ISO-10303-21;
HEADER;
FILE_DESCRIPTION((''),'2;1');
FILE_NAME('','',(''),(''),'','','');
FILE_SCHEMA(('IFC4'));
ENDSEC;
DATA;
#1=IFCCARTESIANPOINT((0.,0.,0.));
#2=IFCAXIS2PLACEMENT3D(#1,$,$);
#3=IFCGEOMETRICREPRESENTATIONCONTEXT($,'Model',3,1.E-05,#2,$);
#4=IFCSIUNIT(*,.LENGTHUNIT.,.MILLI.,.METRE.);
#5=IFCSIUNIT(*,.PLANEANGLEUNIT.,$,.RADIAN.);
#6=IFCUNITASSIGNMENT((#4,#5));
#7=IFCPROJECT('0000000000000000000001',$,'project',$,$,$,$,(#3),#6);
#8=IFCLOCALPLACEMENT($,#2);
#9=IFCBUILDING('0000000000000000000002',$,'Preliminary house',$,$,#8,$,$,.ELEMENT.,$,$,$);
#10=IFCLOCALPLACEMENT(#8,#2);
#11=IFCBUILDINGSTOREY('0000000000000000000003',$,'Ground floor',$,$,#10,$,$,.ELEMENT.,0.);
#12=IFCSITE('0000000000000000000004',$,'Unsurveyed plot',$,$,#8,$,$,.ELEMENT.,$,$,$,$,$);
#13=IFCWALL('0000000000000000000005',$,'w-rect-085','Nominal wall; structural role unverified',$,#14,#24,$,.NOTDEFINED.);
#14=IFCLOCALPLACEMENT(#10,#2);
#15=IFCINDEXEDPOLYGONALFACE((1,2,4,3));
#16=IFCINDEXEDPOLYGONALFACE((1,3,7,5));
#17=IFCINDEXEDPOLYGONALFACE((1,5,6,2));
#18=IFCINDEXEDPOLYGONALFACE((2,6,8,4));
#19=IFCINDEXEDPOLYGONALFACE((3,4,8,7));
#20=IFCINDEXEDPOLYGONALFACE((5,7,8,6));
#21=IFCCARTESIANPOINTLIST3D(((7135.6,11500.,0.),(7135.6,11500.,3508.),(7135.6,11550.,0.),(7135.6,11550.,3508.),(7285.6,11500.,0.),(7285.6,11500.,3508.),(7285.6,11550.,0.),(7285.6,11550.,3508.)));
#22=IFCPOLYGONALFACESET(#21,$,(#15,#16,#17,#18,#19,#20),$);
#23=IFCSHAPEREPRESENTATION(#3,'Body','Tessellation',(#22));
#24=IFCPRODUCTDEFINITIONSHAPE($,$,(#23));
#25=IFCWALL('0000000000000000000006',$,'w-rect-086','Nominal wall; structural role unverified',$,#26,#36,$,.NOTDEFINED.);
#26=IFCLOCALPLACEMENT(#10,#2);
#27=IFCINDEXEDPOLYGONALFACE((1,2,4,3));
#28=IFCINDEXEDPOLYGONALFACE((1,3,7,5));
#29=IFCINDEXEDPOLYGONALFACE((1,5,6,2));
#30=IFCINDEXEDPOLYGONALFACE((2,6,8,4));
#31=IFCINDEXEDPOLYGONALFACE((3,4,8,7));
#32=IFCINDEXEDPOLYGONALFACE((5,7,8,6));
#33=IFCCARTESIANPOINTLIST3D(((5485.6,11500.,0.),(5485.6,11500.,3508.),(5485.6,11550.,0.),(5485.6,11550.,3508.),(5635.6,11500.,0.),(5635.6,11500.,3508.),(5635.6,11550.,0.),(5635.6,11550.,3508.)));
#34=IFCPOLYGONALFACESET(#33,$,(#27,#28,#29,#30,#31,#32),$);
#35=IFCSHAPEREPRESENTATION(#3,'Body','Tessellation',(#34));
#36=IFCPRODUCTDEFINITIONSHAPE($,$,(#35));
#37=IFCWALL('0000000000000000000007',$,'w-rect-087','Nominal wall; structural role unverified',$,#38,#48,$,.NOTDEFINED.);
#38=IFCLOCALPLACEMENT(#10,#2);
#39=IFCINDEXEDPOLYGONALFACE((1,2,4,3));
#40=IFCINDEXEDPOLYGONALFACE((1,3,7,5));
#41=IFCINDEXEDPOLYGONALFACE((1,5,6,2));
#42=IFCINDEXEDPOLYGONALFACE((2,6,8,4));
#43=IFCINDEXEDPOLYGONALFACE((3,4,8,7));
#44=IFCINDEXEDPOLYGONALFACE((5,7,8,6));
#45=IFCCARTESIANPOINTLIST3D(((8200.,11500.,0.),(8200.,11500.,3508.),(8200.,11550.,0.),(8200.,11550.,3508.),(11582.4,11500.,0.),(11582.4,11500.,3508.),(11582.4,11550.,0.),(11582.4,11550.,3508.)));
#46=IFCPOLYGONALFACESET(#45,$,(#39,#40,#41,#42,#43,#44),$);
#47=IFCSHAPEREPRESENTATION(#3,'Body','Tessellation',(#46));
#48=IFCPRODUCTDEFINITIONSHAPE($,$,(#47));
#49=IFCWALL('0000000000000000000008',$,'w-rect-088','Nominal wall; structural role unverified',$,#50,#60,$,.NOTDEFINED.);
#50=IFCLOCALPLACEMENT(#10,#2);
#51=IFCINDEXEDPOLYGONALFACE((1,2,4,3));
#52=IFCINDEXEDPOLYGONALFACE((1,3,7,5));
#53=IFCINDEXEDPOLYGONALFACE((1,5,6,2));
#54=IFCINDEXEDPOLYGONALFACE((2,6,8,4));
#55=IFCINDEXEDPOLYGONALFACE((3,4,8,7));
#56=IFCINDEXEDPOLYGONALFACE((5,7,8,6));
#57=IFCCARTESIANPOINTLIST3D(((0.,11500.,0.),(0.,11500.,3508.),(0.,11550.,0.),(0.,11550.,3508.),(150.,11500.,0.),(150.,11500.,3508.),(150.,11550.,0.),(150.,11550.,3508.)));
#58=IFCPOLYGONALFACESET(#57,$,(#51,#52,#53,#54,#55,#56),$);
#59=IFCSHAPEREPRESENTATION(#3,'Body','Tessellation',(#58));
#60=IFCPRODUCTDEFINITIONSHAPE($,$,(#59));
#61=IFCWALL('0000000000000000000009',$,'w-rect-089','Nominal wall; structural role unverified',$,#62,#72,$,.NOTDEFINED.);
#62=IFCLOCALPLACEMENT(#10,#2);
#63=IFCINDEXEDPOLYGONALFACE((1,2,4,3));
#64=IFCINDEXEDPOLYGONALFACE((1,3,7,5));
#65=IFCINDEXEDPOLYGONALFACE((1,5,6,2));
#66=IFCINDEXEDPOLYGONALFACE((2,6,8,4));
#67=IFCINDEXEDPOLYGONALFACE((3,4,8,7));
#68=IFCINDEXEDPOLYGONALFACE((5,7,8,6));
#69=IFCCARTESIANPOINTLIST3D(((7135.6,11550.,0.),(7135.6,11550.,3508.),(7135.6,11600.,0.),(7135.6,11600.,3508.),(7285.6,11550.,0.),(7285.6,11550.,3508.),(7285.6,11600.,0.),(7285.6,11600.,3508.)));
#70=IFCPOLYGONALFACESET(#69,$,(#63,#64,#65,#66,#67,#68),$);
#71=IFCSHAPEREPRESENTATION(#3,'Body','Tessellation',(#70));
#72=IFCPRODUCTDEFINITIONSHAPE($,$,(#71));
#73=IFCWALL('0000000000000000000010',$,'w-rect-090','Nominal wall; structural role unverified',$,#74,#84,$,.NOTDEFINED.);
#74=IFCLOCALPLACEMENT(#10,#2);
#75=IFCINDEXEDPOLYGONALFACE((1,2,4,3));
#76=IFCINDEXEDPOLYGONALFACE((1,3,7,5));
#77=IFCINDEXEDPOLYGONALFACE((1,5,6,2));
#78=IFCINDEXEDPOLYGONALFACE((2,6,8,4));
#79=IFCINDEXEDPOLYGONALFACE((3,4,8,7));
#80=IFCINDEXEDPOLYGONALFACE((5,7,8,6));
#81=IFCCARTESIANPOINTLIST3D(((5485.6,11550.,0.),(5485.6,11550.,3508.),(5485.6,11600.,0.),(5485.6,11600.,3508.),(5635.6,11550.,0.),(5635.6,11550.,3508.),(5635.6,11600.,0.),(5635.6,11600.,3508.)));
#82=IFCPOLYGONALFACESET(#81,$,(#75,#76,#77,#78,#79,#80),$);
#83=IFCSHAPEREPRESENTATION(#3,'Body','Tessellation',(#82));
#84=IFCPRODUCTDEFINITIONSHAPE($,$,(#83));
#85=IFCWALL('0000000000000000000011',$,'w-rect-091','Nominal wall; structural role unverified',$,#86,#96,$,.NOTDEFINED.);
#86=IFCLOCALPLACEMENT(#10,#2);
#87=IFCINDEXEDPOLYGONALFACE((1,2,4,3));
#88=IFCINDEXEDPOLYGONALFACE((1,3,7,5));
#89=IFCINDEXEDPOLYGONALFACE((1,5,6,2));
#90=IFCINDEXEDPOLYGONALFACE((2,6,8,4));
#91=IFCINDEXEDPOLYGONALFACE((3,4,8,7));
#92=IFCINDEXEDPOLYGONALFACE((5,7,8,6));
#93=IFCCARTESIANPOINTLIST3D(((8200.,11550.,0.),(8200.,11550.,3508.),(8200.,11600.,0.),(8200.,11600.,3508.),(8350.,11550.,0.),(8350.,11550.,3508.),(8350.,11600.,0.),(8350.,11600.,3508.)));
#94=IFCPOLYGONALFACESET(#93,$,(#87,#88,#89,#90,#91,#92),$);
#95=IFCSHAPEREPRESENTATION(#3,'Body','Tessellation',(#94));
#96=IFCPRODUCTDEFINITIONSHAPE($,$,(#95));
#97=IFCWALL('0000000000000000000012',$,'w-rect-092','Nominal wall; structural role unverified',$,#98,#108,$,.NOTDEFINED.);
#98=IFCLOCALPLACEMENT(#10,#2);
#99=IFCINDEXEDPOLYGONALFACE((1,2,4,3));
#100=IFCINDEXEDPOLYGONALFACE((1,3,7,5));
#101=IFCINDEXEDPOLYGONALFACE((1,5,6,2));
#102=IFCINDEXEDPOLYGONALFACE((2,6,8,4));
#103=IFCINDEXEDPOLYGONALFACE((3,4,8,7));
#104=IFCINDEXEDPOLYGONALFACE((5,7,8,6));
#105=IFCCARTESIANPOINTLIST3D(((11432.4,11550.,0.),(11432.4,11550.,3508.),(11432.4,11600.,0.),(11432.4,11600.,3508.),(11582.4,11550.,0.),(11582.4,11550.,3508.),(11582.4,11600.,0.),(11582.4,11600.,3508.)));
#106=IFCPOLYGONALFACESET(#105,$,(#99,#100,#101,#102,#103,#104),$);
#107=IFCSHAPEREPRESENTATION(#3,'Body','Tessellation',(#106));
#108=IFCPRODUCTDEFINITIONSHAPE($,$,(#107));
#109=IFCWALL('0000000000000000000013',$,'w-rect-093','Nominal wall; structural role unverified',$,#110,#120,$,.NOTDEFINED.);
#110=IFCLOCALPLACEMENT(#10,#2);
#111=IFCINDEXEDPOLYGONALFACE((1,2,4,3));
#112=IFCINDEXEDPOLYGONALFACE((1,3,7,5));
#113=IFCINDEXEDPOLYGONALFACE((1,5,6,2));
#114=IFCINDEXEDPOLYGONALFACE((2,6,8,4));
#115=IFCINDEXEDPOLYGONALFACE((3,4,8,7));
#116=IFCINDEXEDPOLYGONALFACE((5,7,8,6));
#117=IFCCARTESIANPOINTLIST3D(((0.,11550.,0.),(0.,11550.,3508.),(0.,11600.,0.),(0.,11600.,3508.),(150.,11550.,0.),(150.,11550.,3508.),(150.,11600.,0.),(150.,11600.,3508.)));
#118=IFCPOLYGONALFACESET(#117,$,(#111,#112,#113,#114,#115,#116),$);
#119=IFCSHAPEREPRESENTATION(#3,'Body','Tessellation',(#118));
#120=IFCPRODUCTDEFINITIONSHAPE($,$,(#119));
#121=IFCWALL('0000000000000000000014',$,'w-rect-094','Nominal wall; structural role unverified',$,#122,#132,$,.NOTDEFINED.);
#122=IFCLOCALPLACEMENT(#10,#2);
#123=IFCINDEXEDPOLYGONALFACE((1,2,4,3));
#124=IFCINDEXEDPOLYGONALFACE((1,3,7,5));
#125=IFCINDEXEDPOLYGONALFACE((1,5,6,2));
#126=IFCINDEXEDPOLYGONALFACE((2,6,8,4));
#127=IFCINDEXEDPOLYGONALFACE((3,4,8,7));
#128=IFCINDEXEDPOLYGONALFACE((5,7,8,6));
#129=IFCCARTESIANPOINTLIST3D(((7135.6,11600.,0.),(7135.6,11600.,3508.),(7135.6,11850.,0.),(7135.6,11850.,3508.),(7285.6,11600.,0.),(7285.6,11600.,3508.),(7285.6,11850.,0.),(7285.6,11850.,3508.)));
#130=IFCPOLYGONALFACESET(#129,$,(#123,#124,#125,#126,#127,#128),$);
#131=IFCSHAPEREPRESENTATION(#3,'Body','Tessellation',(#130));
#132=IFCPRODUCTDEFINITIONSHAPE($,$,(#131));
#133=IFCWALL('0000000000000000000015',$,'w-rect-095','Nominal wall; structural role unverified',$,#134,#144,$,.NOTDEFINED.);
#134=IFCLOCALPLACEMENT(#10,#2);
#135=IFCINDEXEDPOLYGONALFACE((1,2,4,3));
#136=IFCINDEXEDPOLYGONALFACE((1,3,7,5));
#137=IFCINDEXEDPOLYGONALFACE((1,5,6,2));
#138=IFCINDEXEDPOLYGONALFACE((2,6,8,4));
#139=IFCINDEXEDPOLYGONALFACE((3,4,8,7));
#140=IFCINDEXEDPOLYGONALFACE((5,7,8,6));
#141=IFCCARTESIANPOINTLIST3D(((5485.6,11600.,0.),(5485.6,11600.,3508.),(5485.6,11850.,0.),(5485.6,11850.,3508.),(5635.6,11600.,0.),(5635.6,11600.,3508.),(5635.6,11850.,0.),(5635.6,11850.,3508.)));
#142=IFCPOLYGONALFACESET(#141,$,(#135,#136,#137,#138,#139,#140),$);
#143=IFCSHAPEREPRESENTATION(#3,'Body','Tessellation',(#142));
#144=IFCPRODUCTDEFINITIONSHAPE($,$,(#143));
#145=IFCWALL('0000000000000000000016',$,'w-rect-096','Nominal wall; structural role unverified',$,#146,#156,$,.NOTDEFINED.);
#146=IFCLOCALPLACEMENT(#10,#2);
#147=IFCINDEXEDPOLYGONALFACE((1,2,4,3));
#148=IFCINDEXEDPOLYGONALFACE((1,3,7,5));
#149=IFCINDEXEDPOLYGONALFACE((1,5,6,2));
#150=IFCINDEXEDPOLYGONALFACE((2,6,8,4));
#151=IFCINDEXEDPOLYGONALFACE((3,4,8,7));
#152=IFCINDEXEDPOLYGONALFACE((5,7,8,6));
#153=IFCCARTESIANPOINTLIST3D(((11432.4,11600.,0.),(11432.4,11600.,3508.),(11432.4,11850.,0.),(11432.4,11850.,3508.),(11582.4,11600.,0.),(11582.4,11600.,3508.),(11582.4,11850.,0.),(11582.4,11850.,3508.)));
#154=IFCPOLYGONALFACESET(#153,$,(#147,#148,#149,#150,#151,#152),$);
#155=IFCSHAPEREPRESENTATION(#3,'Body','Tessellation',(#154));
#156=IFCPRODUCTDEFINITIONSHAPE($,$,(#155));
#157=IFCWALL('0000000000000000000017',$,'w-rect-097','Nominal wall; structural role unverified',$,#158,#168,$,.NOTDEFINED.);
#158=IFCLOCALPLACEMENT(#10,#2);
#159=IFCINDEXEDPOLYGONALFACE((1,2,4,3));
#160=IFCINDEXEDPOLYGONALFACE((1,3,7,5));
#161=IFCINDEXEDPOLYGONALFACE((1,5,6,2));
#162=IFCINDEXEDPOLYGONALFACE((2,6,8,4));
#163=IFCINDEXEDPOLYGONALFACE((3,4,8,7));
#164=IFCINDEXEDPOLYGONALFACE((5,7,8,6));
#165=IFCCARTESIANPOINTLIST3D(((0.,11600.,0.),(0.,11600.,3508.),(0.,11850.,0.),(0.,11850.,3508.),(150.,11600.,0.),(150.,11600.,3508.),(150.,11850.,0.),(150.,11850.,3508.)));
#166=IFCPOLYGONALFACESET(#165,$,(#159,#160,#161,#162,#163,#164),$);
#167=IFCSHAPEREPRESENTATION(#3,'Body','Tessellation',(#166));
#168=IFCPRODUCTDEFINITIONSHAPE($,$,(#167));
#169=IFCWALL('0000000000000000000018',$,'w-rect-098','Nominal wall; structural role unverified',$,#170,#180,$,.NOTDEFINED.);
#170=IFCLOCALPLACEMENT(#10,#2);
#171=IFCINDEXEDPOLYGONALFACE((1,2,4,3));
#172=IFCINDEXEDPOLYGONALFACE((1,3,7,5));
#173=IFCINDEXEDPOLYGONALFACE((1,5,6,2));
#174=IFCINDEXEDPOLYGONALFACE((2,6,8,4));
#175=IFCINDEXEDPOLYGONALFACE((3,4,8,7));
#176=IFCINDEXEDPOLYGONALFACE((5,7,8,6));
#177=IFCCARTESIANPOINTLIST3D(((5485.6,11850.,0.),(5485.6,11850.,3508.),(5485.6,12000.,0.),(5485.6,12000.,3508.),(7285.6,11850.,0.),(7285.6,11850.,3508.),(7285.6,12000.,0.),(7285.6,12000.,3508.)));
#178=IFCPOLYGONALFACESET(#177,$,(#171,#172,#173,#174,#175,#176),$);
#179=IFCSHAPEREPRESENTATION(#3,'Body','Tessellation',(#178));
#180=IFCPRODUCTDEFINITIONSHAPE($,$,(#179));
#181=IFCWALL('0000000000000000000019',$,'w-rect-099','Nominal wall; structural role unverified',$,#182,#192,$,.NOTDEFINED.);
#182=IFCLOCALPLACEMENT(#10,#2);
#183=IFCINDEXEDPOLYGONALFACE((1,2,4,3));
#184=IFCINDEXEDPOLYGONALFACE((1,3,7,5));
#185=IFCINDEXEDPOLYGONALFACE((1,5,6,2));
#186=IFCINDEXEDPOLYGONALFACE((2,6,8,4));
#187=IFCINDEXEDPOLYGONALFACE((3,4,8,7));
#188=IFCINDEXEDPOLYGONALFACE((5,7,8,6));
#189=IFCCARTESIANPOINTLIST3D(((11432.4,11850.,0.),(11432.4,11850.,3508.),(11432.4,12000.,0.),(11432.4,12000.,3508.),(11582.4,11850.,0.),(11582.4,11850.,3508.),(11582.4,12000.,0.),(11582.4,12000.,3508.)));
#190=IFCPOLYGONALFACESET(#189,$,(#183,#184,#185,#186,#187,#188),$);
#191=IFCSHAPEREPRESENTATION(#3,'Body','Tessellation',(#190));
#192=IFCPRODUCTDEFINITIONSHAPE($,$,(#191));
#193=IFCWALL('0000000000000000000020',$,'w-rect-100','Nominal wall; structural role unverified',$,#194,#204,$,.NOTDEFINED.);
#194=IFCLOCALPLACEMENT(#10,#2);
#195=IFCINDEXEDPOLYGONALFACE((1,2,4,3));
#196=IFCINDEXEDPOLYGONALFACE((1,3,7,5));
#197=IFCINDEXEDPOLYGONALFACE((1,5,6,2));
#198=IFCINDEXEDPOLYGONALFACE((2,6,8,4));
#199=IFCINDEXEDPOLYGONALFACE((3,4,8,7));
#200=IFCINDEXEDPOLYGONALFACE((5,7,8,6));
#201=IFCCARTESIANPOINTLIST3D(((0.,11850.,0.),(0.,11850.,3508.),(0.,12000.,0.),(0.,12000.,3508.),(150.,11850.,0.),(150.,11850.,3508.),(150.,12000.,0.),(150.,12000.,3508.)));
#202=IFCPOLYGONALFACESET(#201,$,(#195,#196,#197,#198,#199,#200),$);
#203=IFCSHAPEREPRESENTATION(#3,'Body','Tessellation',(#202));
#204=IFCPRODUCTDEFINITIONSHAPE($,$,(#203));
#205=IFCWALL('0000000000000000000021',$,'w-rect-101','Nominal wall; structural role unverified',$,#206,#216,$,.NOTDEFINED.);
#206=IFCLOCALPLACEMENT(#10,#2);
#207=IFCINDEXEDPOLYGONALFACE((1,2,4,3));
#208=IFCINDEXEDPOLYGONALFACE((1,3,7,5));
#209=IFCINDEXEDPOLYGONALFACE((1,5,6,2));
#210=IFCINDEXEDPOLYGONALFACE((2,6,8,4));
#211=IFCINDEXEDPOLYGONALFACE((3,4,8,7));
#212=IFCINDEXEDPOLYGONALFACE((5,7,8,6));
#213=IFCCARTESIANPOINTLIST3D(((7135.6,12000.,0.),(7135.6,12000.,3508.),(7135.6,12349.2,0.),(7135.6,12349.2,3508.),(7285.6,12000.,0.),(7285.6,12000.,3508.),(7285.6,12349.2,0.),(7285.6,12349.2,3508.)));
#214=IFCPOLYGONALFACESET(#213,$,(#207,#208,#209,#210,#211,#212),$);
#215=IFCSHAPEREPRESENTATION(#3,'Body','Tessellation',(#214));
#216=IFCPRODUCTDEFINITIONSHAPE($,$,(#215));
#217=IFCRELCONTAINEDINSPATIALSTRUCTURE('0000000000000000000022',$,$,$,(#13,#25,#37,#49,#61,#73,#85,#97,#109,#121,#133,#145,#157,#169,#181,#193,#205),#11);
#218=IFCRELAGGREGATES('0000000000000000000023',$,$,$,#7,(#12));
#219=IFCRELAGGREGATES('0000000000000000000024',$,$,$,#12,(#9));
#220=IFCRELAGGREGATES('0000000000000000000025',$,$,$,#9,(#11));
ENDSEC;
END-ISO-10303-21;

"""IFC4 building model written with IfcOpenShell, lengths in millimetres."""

from ifc_helpers import new_model, si_unit, origin, place, context, project, spatial, polyline, outline, extrude, element, save


model = new_model("IFC4")

# Units and contexts
model_context = context("Model", 3, precision=1e-05, world=origin())
ifc_project = project(units=[si_unit("LENGTHUNIT", "METRE", prefix="MILLI"), si_unit("PLANEANGLEUNIT", "RADIAN")], contexts=[model_context])

# Site, building, storey
placement_1 = place(None, origin())
site = spatial("IfcSite", under=ifc_project, at=placement_1, Name="Unsurveyed plot", CompositionType="ELEMENT")
building = spatial("IfcBuilding", under=site, at=placement_1, Name="Preliminary house", CompositionType="ELEMENT")
placement_2 = place(placement_1, origin())
storey = spatial("IfcBuildingStorey", under=building, at=placement_2, Name="Ground floor", CompositionType="ELEMENT", Elevation=0.0)

# Walls
element("IfcWall", 1, at=placement_2, inside=storey, Name="w-rect-085", Description="Nominal wall; structural role unverified", PredefinedType="NOTDEFINED", context=model_context, shape_type="SweptSolid", body=[
    extrude(outline(polyline([(7135.6, 11500.0), (7285.6, 11500.0), (7285.6, 11550.0), (7135.6, 11550.0), (7135.6, 11500.0)])), origin(), (0.0, 0.0, 1.0), 3508.0),
])
element("IfcWall", 2, at=placement_2, inside=storey, Name="w-rect-086", Description="Nominal wall; structural role unverified", PredefinedType="NOTDEFINED", context=model_context, shape_type="SweptSolid", body=[
    extrude(outline(polyline([(5485.6, 11500.0), (5635.6, 11500.0), (5635.6, 11550.0), (5485.6, 11550.0), (5485.6, 11500.0)])), origin(), (0.0, 0.0, 1.0), 3508.0),
])
element("IfcWall", 3, at=placement_2, inside=storey, Name="w-rect-087", Description="Nominal wall; structural role unverified", PredefinedType="NOTDEFINED", context=model_context, shape_type="SweptSolid", body=[
    extrude(outline(polyline([(8200.0, 11500.0), (11582.4, 11500.0), (11582.4, 11550.0), (8200.0, 11550.0), (8200.0, 11500.0)])), origin(), (0.0, 0.0, 1.0), 3508.0),
])
element("IfcWall", 4, at=placement_2, inside=storey, Name="w-rect-088", Description="Nominal wall; structural role unverified", PredefinedType="NOTDEFINED", context=model_context, shape_type="SweptSolid", body=[
    extrude(outline(polyline([(0.0, 11500.0), (150.0, 11500.0), (150.0, 11550.0), (0.0, 11550.0), (0.0, 11500.0)])), origin(), (0.0, 0.0, 1.0), 3508.0),
])
element("IfcWall", 5, at=placement_2, inside=storey, Name="w-rect-089", Description="Nominal wall; structural role unverified", PredefinedType="NOTDEFINED", context=model_context, shape_type="SweptSolid", body=[
    extrude(outline(polyline([(7135.6, 11550.0), (7285.6, 11550.0), (7285.6, 11600.0), (7135.6, 11600.0), (7135.6, 11550.0)])), origin(), (0.0, 0.0, 1.0), 3508.0),
])
element("IfcWall", 6, at=placement_2, inside=storey, Name="w-rect-090", Description="Nominal wall; structural role unverified", PredefinedType="NOTDEFINED", context=model_context, shape_type="SweptSolid", body=[
    extrude(outline(polyline([(5485.6, 11550.0), (5635.6, 11550.0), (5635.6, 11600.0), (5485.6, 11600.0), (5485.6, 11550.0)])), origin(), (0.0, 0.0, 1.0), 3508.0),
])
element("IfcWall", 7, at=placement_2, inside=storey, Name="w-rect-091", Description="Nominal wall; structural role unverified", PredefinedType="NOTDEFINED", context=model_context, shape_type="SweptSolid", body=[
    extrude(outline(polyline([(8200.0, 11550.0), (8350.0, 11550.0), (8350.0, 11600.0), (8200.0, 11600.0), (8200.0, 11550.0)])), origin(), (0.0, 0.0, 1.0), 3508.0),
])
element("IfcWall", 8, at=placement_2, inside=storey, Name="w-rect-092", Description="Nominal wall; structural role unverified", PredefinedType="NOTDEFINED", context=model_context, shape_type="SweptSolid", body=[
    extrude(outline(polyline([(11432.4, 11550.0), (11582.4, 11550.0), (11582.4, 11600.0), (11432.4, 11600.0), (11432.4, 11550.0)])), origin(), (0.0, 0.0, 1.0), 3508.0),
])
element("IfcWall", 9, at=placement_2, inside=storey, Name="w-rect-093", Description="Nominal wall; structural role unverified", PredefinedType="NOTDEFINED", context=model_context, shape_type="SweptSolid", body=[
    extrude(outline(polyline([(0.0, 11550.0), (150.0, 11550.0), (150.0, 11600.0), (0.0, 11600.0), (0.0, 11550.0)])), origin(), (0.0, 0.0, 1.0), 3508.0),
])
element("IfcWall", 10, at=placement_2, inside=storey, Name="w-rect-094", Description="Nominal wall; structural role unverified", PredefinedType="NOTDEFINED", context=model_context, shape_type="SweptSolid", body=[
    extrude(outline(polyline([(7135.6, 11600.0), (7285.6, 11600.0), (7285.6, 11850.0), (7135.6, 11850.0), (7135.6, 11600.0)])), origin(), (0.0, 0.0, 1.0), 3508.0),
])
element("IfcWall", 11, at=placement_2, inside=storey, Name="w-rect-095", Description="Nominal wall; structural role unverified", PredefinedType="NOTDEFINED", context=model_context, shape_type="SweptSolid", body=[
    extrude(outline(polyline([(5485.6, 11600.0), (5635.6, 11600.0), (5635.6, 11850.0), (5485.6, 11850.0), (5485.6, 11600.0)])), origin(), (0.0, 0.0, 1.0), 3508.0),
])
element("IfcWall", 12, at=placement_2, inside=storey, Name="w-rect-096", Description="Nominal wall; structural role unverified", PredefinedType="NOTDEFINED", context=model_context, shape_type="SweptSolid", body=[
    extrude(outline(polyline([(11432.4, 11600.0), (11582.4, 11600.0), (11582.4, 11850.0), (11432.4, 11850.0), (11432.4, 11600.0)])), origin(), (0.0, 0.0, 1.0), 3508.0),
])
element("IfcWall", 13, at=placement_2, inside=storey, Name="w-rect-097", Description="Nominal wall; structural role unverified", PredefinedType="NOTDEFINED", context=model_context, shape_type="SweptSolid", body=[
    extrude(outline(polyline([(0.0, 11600.0), (150.0, 11600.0), (150.0, 11850.0), (0.0, 11850.0), (0.0, 11600.0)])), origin(), (0.0, 0.0, 1.0), 3508.0),
])
element("IfcWall", 14, at=placement_2, inside=storey, Name="w-rect-098", Description="Nominal wall; structural role unverified", PredefinedType="NOTDEFINED", context=model_context, shape_type="SweptSolid", body=[
    extrude(outline(polyline([(5485.6, 11850.0), (7285.6, 11850.0), (7285.6, 12000.0), (5485.6, 12000.0), (5485.6, 11850.0)])), origin(), (0.0, 0.0, 1.0), 3508.0),
])
element("IfcWall", 15, at=placement_2, inside=storey, Name="w-rect-099", Description="Nominal wall; structural role unverified", PredefinedType="NOTDEFINED", context=model_context, shape_type="SweptSolid", body=[
    extrude(outline(polyline([(11432.4, 11850.0), (11582.4, 11850.0), (11582.4, 12000.0), (11432.4, 12000.0), (11432.4, 11850.0)])), origin(), (0.0, 0.0, 1.0), 3508.0),
])
element("IfcWall", 16, at=placement_2, inside=storey, Name="w-rect-100", Description="Nominal wall; structural role unverified", PredefinedType="NOTDEFINED", context=model_context, shape_type="SweptSolid", body=[
    extrude(outline(polyline([(0.0, 11850.0), (150.0, 11850.0), (150.0, 12000.0), (0.0, 12000.0), (0.0, 11850.0)])), origin(), (0.0, 0.0, 1.0), 3508.0),
])
element("IfcWall", 17, at=placement_2, inside=storey, Name="w-rect-101", Description="Nominal wall; structural role unverified", PredefinedType="NOTDEFINED", context=model_context, shape_type="SweptSolid", body=[
    extrude(outline(polyline([(7135.6, 12000.0), (7285.6, 12000.0), (7285.6, 12349.2), (7135.6, 12349.2), (7135.6, 12000.0)])), origin(), (0.0, 0.0, 1.0), 3508.0),
])

save(model, "model.ifc")
